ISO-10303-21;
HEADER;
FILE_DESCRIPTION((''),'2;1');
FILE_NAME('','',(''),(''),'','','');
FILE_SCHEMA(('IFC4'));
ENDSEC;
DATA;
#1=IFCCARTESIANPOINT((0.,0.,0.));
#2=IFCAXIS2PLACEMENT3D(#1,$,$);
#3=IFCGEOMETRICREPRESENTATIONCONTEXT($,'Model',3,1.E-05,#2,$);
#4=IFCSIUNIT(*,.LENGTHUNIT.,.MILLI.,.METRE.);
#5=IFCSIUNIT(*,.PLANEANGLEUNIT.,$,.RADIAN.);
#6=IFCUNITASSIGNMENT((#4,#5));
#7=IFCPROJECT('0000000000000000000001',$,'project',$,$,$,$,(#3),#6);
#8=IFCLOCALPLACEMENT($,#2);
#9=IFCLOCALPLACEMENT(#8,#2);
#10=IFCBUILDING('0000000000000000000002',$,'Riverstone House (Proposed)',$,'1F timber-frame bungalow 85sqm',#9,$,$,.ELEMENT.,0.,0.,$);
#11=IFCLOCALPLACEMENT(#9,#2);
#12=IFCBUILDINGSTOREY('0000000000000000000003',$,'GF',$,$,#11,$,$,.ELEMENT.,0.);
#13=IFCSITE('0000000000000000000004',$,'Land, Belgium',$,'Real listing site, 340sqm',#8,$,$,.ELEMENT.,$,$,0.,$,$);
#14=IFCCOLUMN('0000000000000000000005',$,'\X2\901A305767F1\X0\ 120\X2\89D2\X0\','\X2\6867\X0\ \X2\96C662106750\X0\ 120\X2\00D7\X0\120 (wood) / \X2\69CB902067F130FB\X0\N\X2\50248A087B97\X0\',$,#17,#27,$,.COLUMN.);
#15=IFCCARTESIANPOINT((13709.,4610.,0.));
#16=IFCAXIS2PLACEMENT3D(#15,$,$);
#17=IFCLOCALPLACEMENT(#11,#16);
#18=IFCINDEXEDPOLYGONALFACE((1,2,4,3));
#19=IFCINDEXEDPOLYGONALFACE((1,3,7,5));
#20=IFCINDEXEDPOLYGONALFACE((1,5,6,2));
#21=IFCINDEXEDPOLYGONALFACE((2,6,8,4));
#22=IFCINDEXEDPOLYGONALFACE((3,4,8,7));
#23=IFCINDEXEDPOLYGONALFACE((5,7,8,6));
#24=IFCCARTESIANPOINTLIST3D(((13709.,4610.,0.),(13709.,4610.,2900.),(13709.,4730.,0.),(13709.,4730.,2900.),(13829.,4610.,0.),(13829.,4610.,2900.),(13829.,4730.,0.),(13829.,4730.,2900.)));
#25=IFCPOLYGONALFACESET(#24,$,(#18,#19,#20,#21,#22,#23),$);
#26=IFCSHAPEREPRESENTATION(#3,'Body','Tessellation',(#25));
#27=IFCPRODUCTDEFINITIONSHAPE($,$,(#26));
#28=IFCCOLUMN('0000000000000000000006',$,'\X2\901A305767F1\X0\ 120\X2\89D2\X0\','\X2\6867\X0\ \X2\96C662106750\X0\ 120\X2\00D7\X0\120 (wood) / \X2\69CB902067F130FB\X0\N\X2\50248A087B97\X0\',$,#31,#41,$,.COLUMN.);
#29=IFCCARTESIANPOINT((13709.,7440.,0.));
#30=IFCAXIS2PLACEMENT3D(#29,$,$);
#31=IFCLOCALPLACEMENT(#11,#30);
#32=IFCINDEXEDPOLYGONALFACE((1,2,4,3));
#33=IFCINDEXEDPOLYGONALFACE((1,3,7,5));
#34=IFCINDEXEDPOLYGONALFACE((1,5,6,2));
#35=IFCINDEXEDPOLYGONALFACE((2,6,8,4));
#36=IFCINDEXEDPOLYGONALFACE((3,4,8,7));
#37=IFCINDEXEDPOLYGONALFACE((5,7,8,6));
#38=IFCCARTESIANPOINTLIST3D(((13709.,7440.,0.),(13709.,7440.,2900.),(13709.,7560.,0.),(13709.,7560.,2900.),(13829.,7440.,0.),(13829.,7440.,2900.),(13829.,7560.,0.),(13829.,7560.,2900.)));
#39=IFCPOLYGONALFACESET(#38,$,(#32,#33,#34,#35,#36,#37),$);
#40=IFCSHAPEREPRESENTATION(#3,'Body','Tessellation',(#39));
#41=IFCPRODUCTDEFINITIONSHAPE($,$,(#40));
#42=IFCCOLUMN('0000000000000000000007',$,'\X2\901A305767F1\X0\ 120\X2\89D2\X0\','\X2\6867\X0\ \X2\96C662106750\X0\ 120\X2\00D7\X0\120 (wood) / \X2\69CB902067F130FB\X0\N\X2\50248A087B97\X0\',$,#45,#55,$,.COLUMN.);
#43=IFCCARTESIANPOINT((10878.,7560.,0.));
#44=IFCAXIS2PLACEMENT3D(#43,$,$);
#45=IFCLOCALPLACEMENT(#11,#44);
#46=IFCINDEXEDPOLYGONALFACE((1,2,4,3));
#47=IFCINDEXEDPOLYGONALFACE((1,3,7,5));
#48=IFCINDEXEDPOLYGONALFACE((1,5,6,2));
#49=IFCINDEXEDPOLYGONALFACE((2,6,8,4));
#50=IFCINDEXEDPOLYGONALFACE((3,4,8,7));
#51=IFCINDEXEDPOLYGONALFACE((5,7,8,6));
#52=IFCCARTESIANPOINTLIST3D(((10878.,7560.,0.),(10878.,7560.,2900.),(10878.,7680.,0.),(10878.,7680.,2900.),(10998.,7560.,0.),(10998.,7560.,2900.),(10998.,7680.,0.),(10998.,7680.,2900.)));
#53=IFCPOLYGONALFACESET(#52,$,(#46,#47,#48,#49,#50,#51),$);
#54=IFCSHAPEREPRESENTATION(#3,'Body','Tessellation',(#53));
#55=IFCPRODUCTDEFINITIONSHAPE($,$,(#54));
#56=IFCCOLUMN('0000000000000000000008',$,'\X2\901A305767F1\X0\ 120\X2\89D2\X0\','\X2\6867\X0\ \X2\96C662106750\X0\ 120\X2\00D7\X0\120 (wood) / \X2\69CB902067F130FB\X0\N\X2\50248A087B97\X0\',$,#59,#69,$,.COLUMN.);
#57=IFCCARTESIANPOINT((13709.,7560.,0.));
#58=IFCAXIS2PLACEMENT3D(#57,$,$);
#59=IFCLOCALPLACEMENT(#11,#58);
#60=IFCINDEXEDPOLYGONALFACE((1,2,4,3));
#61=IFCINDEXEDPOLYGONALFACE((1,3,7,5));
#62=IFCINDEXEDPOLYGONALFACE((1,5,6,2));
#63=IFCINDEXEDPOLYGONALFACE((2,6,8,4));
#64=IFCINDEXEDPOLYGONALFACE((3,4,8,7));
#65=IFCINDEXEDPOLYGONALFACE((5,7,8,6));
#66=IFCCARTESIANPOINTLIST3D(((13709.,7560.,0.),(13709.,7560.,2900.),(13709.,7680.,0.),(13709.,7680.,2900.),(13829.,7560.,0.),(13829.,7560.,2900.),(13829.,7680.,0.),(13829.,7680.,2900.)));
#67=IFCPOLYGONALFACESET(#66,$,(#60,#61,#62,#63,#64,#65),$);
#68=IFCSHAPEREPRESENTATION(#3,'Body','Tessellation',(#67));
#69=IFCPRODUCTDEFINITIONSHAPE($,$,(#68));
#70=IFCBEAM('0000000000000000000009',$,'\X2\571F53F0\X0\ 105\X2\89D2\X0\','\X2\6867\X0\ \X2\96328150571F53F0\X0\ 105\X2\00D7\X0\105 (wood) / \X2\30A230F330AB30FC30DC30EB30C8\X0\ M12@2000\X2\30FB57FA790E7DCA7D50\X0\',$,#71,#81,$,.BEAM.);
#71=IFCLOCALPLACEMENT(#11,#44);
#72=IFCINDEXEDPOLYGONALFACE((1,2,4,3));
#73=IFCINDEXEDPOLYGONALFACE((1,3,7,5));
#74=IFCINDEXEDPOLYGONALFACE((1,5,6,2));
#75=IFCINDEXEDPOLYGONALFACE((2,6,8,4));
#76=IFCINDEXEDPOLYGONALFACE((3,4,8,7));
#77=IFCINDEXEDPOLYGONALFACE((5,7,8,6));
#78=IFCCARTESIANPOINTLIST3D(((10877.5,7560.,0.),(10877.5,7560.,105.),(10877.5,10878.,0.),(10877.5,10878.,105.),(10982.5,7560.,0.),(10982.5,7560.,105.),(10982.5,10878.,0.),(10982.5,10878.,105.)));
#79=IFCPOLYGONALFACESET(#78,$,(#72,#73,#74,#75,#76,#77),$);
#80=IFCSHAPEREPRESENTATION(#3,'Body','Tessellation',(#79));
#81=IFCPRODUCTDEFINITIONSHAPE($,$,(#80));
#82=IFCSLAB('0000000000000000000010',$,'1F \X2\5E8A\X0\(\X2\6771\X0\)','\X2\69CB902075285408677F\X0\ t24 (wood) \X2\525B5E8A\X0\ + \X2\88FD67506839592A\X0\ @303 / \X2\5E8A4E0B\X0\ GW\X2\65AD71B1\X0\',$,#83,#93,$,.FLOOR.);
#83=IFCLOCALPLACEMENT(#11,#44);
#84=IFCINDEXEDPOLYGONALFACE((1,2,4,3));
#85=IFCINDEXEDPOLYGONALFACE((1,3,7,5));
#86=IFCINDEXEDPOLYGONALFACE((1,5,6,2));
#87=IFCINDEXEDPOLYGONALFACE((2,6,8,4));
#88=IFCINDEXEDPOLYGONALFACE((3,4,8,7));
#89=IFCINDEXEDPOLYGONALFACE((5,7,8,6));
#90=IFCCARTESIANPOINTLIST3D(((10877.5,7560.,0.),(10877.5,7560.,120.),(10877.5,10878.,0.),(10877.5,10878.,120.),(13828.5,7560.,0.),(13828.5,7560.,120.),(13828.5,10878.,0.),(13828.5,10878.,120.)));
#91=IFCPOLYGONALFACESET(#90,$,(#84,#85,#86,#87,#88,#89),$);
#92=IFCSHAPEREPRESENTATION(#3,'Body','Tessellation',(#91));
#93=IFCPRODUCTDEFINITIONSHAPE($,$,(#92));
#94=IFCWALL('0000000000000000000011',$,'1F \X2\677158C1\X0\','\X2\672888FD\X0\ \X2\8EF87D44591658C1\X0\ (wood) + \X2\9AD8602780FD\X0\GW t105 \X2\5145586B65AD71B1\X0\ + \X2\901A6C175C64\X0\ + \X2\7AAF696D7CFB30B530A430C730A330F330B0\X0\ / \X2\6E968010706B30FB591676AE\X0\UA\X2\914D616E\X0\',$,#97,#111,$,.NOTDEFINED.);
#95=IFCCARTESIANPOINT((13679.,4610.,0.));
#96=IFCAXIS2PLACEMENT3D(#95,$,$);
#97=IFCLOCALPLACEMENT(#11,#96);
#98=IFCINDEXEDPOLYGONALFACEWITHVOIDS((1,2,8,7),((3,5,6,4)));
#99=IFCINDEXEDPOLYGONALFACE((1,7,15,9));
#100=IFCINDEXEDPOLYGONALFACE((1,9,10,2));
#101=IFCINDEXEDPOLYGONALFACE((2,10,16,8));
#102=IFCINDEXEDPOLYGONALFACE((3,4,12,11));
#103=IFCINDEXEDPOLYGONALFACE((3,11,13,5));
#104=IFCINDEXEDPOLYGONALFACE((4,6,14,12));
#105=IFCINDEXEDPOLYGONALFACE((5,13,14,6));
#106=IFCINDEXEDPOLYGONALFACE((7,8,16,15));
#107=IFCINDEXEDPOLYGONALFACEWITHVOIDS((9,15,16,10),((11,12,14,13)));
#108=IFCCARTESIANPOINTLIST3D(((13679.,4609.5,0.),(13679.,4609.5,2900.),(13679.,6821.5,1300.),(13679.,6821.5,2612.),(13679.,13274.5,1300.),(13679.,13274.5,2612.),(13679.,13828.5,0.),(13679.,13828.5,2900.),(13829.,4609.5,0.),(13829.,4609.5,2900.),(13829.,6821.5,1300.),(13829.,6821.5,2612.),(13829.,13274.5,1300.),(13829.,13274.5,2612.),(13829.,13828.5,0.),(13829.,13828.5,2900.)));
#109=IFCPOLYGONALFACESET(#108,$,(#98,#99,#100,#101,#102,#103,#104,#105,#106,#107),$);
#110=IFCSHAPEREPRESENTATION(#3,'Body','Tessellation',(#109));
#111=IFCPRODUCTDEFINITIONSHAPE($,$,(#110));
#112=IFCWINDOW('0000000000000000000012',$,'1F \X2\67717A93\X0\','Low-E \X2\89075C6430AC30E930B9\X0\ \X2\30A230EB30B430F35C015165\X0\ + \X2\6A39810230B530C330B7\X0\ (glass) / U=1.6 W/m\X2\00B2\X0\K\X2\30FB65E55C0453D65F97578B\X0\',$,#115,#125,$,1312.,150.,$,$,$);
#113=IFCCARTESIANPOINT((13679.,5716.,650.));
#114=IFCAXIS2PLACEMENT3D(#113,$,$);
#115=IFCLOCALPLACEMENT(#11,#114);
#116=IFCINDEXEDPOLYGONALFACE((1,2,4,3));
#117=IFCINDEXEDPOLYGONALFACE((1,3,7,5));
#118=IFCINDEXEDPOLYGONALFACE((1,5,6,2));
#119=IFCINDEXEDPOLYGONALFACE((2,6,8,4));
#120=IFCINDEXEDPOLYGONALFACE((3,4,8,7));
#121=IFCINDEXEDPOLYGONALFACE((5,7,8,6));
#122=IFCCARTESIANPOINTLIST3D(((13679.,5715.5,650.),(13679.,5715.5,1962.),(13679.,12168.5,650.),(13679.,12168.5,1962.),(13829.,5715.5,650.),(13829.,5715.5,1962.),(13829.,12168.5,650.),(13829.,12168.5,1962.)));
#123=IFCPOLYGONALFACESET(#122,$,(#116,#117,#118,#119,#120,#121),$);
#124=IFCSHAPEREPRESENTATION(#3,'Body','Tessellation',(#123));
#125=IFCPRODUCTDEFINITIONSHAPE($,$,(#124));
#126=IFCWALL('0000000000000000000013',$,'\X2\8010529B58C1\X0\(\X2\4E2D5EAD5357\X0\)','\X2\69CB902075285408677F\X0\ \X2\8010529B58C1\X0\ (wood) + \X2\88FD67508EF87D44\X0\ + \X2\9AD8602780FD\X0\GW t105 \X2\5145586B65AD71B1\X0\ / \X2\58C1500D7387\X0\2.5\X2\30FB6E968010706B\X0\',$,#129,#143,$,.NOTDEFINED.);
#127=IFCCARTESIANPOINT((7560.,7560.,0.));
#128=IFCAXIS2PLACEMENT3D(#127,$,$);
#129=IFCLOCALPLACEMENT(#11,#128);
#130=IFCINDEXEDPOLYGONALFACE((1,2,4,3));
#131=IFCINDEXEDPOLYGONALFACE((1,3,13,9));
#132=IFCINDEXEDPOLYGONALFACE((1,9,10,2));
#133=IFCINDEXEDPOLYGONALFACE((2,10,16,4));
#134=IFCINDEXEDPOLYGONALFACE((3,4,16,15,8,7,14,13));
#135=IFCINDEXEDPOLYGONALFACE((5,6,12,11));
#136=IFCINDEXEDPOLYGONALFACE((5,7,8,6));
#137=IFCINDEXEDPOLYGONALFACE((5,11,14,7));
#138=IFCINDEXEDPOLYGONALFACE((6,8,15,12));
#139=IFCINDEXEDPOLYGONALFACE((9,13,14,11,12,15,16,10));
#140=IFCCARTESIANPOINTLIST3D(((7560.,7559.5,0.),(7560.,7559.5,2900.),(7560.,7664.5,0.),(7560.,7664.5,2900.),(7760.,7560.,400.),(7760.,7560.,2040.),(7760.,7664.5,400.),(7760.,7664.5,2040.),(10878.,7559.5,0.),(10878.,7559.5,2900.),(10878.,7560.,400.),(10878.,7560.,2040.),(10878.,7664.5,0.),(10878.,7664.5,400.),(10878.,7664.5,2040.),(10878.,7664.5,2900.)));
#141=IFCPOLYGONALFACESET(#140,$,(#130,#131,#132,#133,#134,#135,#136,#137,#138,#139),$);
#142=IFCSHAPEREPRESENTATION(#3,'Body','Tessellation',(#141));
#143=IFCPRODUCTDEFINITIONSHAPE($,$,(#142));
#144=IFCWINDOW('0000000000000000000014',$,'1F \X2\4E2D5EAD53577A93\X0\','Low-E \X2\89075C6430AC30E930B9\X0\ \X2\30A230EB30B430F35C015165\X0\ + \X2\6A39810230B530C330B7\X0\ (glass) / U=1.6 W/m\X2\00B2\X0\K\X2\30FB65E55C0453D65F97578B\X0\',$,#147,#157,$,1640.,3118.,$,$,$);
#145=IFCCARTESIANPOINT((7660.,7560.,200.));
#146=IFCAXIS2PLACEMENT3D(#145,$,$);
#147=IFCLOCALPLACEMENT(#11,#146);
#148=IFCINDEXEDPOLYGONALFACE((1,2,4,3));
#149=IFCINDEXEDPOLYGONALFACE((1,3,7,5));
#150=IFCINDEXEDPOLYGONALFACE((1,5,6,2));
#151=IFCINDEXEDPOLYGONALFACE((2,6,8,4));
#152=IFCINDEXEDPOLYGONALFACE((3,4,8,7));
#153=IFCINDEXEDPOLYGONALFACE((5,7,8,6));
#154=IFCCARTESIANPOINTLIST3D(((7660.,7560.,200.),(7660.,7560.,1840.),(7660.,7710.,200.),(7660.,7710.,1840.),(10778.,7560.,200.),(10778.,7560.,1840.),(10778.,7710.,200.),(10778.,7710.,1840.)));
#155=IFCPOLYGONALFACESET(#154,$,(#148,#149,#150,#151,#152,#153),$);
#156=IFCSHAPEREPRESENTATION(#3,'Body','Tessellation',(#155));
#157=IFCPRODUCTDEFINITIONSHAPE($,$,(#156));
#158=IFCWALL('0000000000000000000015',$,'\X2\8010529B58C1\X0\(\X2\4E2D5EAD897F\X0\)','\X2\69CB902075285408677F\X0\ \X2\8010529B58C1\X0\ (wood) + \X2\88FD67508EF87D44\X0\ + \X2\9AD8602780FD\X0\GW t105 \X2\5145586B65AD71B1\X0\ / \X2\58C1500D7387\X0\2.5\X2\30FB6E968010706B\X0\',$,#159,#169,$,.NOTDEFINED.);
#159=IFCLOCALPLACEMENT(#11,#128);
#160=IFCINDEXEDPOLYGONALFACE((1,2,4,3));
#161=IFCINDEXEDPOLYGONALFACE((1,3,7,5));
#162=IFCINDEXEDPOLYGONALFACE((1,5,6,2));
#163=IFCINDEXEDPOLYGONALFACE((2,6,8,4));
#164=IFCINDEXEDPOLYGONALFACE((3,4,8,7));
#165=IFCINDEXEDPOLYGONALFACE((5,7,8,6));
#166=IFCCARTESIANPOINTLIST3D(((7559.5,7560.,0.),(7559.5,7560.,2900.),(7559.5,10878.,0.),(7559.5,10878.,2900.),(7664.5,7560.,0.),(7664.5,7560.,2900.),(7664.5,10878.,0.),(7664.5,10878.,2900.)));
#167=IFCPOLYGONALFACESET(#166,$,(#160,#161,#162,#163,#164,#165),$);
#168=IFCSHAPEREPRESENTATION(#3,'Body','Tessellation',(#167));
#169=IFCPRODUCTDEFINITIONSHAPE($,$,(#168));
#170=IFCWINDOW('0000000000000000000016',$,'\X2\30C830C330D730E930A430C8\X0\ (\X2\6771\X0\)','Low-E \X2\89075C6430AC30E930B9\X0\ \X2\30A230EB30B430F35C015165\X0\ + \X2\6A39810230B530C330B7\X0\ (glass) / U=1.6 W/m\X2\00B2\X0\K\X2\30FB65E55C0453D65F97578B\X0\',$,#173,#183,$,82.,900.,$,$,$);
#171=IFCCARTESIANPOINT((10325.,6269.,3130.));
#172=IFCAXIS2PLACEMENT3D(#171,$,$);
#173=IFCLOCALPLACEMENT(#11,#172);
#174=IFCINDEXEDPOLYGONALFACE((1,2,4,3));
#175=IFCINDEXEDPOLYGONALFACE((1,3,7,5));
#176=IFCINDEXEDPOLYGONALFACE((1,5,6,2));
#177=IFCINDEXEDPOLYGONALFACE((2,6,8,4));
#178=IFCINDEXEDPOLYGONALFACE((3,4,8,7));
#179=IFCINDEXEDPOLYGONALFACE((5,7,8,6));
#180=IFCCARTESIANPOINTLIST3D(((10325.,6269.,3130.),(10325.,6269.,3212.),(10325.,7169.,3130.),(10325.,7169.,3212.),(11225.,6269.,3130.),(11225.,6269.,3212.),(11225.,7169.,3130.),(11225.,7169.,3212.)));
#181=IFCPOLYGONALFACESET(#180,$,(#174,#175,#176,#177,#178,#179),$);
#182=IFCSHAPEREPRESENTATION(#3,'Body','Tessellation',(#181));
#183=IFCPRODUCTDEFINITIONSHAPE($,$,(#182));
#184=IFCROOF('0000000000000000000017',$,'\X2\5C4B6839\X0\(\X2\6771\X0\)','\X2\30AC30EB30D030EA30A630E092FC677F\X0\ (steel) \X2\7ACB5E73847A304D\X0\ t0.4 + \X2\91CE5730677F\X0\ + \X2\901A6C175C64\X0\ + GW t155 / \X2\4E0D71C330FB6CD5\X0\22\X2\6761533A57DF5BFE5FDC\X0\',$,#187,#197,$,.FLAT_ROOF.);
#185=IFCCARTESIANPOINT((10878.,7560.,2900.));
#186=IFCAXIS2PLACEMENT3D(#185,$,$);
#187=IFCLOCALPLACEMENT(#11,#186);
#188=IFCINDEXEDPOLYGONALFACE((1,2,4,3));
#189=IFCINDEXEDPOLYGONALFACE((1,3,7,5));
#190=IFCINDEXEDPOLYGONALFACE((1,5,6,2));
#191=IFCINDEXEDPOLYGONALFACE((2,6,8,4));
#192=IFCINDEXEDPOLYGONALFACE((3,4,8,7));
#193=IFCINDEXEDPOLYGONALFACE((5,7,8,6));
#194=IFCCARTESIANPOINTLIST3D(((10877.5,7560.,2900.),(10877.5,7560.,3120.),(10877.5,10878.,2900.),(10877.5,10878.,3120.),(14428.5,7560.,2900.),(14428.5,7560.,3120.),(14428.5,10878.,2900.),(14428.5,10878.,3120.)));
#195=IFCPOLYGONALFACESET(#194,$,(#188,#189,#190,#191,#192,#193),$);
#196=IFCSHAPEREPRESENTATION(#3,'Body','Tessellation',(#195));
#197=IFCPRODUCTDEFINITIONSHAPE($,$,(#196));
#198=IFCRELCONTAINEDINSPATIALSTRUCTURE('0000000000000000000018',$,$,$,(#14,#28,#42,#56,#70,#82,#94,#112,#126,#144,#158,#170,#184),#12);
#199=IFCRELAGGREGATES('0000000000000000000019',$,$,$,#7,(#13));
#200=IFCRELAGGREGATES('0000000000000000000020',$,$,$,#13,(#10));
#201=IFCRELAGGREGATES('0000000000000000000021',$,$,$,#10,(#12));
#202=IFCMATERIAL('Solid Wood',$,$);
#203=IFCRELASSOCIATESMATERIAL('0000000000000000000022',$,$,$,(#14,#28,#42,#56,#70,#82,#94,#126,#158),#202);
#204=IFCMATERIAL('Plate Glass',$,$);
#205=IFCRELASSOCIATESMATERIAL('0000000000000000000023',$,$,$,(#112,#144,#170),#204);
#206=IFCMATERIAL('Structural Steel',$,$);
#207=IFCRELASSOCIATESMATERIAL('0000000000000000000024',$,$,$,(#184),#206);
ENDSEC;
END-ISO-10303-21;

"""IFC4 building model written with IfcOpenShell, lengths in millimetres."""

from ifc_helpers import new_model, si_unit, frame, frame_2d, origin, place, context, project, spatial, rectangle, extrude, material, element, fill, save


model = new_model("IFC4")

# Units and contexts
model_context = context("Model", 3, precision=1e-05, world=origin())
ifc_project = project(units=[si_unit("LENGTHUNIT", "METRE", prefix="MILLI"), si_unit("PLANEANGLEUNIT", "RADIAN")], contexts=[model_context])

# Site, building, storey
site_placement = place(None, origin())
site = spatial("IfcSite", under=ifc_project, at=site_placement, Name="Land, Belgium", ObjectType="Real listing site, 340sqm", CompositionType="ELEMENT", RefElevation=0.0)
building_placement = place(site_placement, origin())
building = spatial("IfcBuilding", under=site, at=building_placement, Name="Riverstone House (Proposed)", ObjectType="1F timber-frame bungalow 85sqm", CompositionType="ELEMENT", ElevationOfRefHeight=0.0, ElevationOfTerrain=0.0)
storey_placement = place(building_placement, origin())
storey = spatial("IfcBuildingStorey", under=building, at=storey_placement, Name="GF", CompositionType="ELEMENT", Elevation=0.0)

# Columns
ifc_material_1 = material(Name="Solid Wood")
column_1_placement = place(storey_placement, frame((13709.0, 4610.0, 0.0)))
element("IfcColumn", 1, at=column_1_placement, inside=storey, material=ifc_material_1, Name="通し柱 120角", Description="桧 集成材 120×120 (wood) / 構造柱・N値計算", PredefinedType="COLUMN", context=model_context, shape_type="SweptSolid", body=[
    extrude(rectangle(XDim=120.0, YDim=120.0, at=frame_2d((60.0, 60.0))), frame((13709.0, 4610.0, 0.0)), (0.0, 0.0, 1.0), 2900.0),
])
column_2_placement = place(storey_placement, frame((13709.0, 7440.0, 0.0)))
element("IfcColumn", 2, at=column_2_placement, inside=storey, material=ifc_material_1, Name="通し柱 120角", Description="桧 集成材 120×120 (wood) / 構造柱・N値計算", PredefinedType="COLUMN", context=model_context, shape_type="SweptSolid", body=[
    extrude(rectangle(XDim=120.0, YDim=120.0, at=frame_2d((60.0, 60.0))), frame((13709.0, 7440.0, 0.0)), (0.0, 0.0, 1.0), 2900.0),
])
column_3_placement = place(storey_placement, frame((10878.0, 7560.0, 0.0)))
element("IfcColumn", 3, at=column_3_placement, inside=storey, material=ifc_material_1, Name="通し柱 120角", Description="桧 集成材 120×120 (wood) / 構造柱・N値計算", PredefinedType="COLUMN", context=model_context, shape_type="SweptSolid", body=[
    extrude(rectangle(XDim=120.0, YDim=120.0, at=frame_2d((60.0, 60.0))), frame((10878.0, 7560.0, 0.0)), (0.0, 0.0, 1.0), 2900.0),
])
column_4_placement = place(storey_placement, frame((13709.0, 7560.0, 0.0)))
element("IfcColumn", 4, at=column_4_placement, inside=storey, material=ifc_material_1, Name="通し柱 120角", Description="桧 集成材 120×120 (wood) / 構造柱・N値計算", PredefinedType="COLUMN", context=model_context, shape_type="SweptSolid", body=[
    extrude(rectangle(XDim=120.0, YDim=120.0, at=frame_2d((60.0, 60.0))), frame((13709.0, 7560.0, 0.0)), (0.0, 0.0, 1.0), 2900.0),
])

# Beam
beam_1_placement = place(storey_placement, frame((10878.0, 7560.0, 0.0)))
element("IfcBeam", 5, at=beam_1_placement, inside=storey, material=ifc_material_1, Name="土台 105角", Description="桧 防腐土台 105×105 (wood) / アンカーボルト M12@2000・基礎緊結", PredefinedType="BEAM", context=model_context, shape_type="SweptSolid", body=[
    extrude(rectangle(XDim=105.0, YDim=3318.0, at=frame_2d((52.0, 1659.0))), frame((10878.0, 7560.0, 0.0)), (0.0, 0.0, 1.0), 105.0),
])

# Slab
slab_placement = place(storey_placement, frame((10878.0, 7560.0, 0.0)))
element("IfcSlab", 6, at=slab_placement, inside=storey, material=ifc_material_1, Name="1F 床(東)", Description="構造用合板 t24 (wood) 剛床 + 製材根太 @303 / 床下 GW断熱", PredefinedType="FLOOR", context=model_context, shape_type="SweptSolid", body=[
    extrude(rectangle(XDim=2951.0, YDim=3318.0, at=frame_2d((1475.0, 1659.0))), frame((10878.0, 7560.0, 0.0)), (0.0, 0.0, 1.0), 120.0),
])

# Walls, openings, windows
wall_1_placement = place(storey_placement, frame((13679.0, 4610.0, 0.0)))
wall_1 = element("IfcWall", 7, at=wall_1_placement, inside=storey, material=ifc_material_1, Name="1F 東壁", Description="木製 軸組外壁 (wood) + 高性能GW t105 充填断熱 + 通気層 + 窯業系サイディング / 準耐火・外皮UA配慮", PredefinedType="NOTDEFINED", context=model_context, shape_type="SweptSolid", body=[
    extrude(rectangle(XDim=150.0, YDim=9219.0, at=frame_2d((75.0, 4609.0))), frame((13679.0, 4610.0, 0.0)), (0.0, 0.0, 1.0), 2900.0),
])
opening_1_placement = place(storey_placement, frame((13679.0, 5716.0, 650.0)))
opening_1 = element("IfcOpeningElement", 8, at=opening_1_placement, cuts=wall_1, PredefinedType="NOTDEFINED", context=model_context, shape_type="SweptSolid", body=[
    extrude(rectangle(XDim=150.0, YDim=6453.0, at=frame_2d((75.0, 3226.0))), frame((13679.0, 5716.0, 650.0)), (0.0, 0.0, 1.0), 1312.0),
])
ifc_material_2 = material(Name="Plate Glass")
window_1_placement = place(storey_placement, frame((13679.0, 5716.0, 650.0)))
window_1 = element("IfcWindow", 9, at=window_1_placement, inside=storey, material=ifc_material_2, Name="1F 東窓", Description="Low-E 複層ガラス アルゴン封入 + 樹脂サッシ (glass) / U=1.6 W/m²K・日射取得型", OverallHeight=1312.0, OverallWidth=150.0, context=model_context, shape_type="SweptSolid", body=[
    extrude(rectangle(XDim=150.0, YDim=6453.0, at=frame_2d((75.0, 3226.0))), frame((13679.0, 5716.0, 650.0)), (0.0, 0.0, 1.0), 1312.0),
])
fill(opening_1, window_1)
wall_2_placement = place(storey_placement, frame((7560.0, 7560.0, 0.0)))
wall_2 = element("IfcWall", 10, at=wall_2_placement, inside=storey, material=ifc_material_1, Name="耐力壁(中庭南)", Description="構造用合板 耐力壁 (wood) + 製材軸組 + 高性能GW t105 充填断熱 / 壁倍率2.5・準耐火", PredefinedType="NOTDEFINED", context=model_context, shape_type="SweptSolid", body=[
    extrude(rectangle(XDim=3318.0, YDim=105.0, at=frame_2d((1659.0, 52.0))), frame((7560.0, 7560.0, 0.0)), (0.0, 0.0, 1.0), 2900.0),
])
opening_2_placement = place(storey_placement, frame((7660.0, 7560.0, 200.0)))
opening_2 = element("IfcOpeningElement", 11, at=opening_2_placement, cuts=wall_2, PredefinedType="NOTDEFINED", context=model_context, shape_type="SweptSolid", body=[
    extrude(rectangle(XDim=3118.0, YDim=150.0, at=frame_2d((1559.0, 75.0))), frame((7660.0, 7560.0, 200.0)), (0.0, 0.0, 1.0), 1640.0),
])
window_2_placement = place(storey_placement, frame((7660.0, 7560.0, 200.0)))
window_2 = element("IfcWindow", 12, at=window_2_placement, inside=storey, material=ifc_material_2, Name="1F 中庭南窓", Description="Low-E 複層ガラス アルゴン封入 + 樹脂サッシ (glass) / U=1.6 W/m²K・日射取得型", OverallHeight=1640.0, OverallWidth=3118.0, context=model_context, shape_type="SweptSolid", body=[
    extrude(rectangle(XDim=3118.0, YDim=150.0, at=frame_2d((1559.0, 75.0))), frame((7660.0, 7560.0, 200.0)), (0.0, 0.0, 1.0), 1640.0),
])
fill(opening_2, window_2)

# Wall
wall_3_placement = place(storey_placement, frame((7560.0, 7560.0, 0.0)))
element("IfcWall", 13, at=wall_3_placement, inside=storey, material=ifc_material_1, Name="耐力壁(中庭西)", Description="構造用合板 耐力壁 (wood) + 製材軸組 + 高性能GW t105 充填断熱 / 壁倍率2.5・準耐火", PredefinedType="NOTDEFINED", context=model_context, shape_type="SweptSolid", body=[
    extrude(rectangle(XDim=105.0, YDim=3318.0, at=frame_2d((52.0, 1659.0))), frame((7560.0, 7560.0, 0.0)), (0.0, 0.0, 1.0), 2900.0),
])

# Window
window_3_placement = place(storey_placement, frame((10325.0, 6269.0, 3130.0)))
element("IfcWindow", 14, at=window_3_placement, inside=storey, material=ifc_material_2, Name="トップライト (東)", Description="Low-E 複層ガラス アルゴン封入 + 樹脂サッシ (glass) / U=1.6 W/m²K・日射取得型", OverallHeight=82.0, OverallWidth=900.0, context=model_context, shape_type="SweptSolid", body=[
    extrude(rectangle(XDim=900.0, YDim=900.0, at=frame_2d((450.0, 450.0))), frame((10325.0, 6269.0, 3130.0)), (0.0, 0.0, 1.0), 82.0),
])

# Roof
ifc_material_3 = material(Name="Structural Steel")
roof_placement = place(storey_placement, frame((10878.0, 7560.0, 2900.0)))
element("IfcRoof", 15, at=roof_placement, inside=storey, material=ifc_material_3, Name="屋根(東)", Description="ガルバリウム鋼板 (steel) 立平葺き t0.4 + 野地板 + 通気層 + GW t155 / 不燃・法22条区域対応", PredefinedType="FLAT_ROOF", context=model_context, shape_type="SweptSolid", body=[
    extrude(rectangle(XDim=3551.0, YDim=3318.0, at=frame_2d((1775.0, 1659.0))), frame((10878.0, 7560.0, 2900.0)), (0.0, 0.0, 1.0), 220.0),
])

save(model, "model.ifc")
